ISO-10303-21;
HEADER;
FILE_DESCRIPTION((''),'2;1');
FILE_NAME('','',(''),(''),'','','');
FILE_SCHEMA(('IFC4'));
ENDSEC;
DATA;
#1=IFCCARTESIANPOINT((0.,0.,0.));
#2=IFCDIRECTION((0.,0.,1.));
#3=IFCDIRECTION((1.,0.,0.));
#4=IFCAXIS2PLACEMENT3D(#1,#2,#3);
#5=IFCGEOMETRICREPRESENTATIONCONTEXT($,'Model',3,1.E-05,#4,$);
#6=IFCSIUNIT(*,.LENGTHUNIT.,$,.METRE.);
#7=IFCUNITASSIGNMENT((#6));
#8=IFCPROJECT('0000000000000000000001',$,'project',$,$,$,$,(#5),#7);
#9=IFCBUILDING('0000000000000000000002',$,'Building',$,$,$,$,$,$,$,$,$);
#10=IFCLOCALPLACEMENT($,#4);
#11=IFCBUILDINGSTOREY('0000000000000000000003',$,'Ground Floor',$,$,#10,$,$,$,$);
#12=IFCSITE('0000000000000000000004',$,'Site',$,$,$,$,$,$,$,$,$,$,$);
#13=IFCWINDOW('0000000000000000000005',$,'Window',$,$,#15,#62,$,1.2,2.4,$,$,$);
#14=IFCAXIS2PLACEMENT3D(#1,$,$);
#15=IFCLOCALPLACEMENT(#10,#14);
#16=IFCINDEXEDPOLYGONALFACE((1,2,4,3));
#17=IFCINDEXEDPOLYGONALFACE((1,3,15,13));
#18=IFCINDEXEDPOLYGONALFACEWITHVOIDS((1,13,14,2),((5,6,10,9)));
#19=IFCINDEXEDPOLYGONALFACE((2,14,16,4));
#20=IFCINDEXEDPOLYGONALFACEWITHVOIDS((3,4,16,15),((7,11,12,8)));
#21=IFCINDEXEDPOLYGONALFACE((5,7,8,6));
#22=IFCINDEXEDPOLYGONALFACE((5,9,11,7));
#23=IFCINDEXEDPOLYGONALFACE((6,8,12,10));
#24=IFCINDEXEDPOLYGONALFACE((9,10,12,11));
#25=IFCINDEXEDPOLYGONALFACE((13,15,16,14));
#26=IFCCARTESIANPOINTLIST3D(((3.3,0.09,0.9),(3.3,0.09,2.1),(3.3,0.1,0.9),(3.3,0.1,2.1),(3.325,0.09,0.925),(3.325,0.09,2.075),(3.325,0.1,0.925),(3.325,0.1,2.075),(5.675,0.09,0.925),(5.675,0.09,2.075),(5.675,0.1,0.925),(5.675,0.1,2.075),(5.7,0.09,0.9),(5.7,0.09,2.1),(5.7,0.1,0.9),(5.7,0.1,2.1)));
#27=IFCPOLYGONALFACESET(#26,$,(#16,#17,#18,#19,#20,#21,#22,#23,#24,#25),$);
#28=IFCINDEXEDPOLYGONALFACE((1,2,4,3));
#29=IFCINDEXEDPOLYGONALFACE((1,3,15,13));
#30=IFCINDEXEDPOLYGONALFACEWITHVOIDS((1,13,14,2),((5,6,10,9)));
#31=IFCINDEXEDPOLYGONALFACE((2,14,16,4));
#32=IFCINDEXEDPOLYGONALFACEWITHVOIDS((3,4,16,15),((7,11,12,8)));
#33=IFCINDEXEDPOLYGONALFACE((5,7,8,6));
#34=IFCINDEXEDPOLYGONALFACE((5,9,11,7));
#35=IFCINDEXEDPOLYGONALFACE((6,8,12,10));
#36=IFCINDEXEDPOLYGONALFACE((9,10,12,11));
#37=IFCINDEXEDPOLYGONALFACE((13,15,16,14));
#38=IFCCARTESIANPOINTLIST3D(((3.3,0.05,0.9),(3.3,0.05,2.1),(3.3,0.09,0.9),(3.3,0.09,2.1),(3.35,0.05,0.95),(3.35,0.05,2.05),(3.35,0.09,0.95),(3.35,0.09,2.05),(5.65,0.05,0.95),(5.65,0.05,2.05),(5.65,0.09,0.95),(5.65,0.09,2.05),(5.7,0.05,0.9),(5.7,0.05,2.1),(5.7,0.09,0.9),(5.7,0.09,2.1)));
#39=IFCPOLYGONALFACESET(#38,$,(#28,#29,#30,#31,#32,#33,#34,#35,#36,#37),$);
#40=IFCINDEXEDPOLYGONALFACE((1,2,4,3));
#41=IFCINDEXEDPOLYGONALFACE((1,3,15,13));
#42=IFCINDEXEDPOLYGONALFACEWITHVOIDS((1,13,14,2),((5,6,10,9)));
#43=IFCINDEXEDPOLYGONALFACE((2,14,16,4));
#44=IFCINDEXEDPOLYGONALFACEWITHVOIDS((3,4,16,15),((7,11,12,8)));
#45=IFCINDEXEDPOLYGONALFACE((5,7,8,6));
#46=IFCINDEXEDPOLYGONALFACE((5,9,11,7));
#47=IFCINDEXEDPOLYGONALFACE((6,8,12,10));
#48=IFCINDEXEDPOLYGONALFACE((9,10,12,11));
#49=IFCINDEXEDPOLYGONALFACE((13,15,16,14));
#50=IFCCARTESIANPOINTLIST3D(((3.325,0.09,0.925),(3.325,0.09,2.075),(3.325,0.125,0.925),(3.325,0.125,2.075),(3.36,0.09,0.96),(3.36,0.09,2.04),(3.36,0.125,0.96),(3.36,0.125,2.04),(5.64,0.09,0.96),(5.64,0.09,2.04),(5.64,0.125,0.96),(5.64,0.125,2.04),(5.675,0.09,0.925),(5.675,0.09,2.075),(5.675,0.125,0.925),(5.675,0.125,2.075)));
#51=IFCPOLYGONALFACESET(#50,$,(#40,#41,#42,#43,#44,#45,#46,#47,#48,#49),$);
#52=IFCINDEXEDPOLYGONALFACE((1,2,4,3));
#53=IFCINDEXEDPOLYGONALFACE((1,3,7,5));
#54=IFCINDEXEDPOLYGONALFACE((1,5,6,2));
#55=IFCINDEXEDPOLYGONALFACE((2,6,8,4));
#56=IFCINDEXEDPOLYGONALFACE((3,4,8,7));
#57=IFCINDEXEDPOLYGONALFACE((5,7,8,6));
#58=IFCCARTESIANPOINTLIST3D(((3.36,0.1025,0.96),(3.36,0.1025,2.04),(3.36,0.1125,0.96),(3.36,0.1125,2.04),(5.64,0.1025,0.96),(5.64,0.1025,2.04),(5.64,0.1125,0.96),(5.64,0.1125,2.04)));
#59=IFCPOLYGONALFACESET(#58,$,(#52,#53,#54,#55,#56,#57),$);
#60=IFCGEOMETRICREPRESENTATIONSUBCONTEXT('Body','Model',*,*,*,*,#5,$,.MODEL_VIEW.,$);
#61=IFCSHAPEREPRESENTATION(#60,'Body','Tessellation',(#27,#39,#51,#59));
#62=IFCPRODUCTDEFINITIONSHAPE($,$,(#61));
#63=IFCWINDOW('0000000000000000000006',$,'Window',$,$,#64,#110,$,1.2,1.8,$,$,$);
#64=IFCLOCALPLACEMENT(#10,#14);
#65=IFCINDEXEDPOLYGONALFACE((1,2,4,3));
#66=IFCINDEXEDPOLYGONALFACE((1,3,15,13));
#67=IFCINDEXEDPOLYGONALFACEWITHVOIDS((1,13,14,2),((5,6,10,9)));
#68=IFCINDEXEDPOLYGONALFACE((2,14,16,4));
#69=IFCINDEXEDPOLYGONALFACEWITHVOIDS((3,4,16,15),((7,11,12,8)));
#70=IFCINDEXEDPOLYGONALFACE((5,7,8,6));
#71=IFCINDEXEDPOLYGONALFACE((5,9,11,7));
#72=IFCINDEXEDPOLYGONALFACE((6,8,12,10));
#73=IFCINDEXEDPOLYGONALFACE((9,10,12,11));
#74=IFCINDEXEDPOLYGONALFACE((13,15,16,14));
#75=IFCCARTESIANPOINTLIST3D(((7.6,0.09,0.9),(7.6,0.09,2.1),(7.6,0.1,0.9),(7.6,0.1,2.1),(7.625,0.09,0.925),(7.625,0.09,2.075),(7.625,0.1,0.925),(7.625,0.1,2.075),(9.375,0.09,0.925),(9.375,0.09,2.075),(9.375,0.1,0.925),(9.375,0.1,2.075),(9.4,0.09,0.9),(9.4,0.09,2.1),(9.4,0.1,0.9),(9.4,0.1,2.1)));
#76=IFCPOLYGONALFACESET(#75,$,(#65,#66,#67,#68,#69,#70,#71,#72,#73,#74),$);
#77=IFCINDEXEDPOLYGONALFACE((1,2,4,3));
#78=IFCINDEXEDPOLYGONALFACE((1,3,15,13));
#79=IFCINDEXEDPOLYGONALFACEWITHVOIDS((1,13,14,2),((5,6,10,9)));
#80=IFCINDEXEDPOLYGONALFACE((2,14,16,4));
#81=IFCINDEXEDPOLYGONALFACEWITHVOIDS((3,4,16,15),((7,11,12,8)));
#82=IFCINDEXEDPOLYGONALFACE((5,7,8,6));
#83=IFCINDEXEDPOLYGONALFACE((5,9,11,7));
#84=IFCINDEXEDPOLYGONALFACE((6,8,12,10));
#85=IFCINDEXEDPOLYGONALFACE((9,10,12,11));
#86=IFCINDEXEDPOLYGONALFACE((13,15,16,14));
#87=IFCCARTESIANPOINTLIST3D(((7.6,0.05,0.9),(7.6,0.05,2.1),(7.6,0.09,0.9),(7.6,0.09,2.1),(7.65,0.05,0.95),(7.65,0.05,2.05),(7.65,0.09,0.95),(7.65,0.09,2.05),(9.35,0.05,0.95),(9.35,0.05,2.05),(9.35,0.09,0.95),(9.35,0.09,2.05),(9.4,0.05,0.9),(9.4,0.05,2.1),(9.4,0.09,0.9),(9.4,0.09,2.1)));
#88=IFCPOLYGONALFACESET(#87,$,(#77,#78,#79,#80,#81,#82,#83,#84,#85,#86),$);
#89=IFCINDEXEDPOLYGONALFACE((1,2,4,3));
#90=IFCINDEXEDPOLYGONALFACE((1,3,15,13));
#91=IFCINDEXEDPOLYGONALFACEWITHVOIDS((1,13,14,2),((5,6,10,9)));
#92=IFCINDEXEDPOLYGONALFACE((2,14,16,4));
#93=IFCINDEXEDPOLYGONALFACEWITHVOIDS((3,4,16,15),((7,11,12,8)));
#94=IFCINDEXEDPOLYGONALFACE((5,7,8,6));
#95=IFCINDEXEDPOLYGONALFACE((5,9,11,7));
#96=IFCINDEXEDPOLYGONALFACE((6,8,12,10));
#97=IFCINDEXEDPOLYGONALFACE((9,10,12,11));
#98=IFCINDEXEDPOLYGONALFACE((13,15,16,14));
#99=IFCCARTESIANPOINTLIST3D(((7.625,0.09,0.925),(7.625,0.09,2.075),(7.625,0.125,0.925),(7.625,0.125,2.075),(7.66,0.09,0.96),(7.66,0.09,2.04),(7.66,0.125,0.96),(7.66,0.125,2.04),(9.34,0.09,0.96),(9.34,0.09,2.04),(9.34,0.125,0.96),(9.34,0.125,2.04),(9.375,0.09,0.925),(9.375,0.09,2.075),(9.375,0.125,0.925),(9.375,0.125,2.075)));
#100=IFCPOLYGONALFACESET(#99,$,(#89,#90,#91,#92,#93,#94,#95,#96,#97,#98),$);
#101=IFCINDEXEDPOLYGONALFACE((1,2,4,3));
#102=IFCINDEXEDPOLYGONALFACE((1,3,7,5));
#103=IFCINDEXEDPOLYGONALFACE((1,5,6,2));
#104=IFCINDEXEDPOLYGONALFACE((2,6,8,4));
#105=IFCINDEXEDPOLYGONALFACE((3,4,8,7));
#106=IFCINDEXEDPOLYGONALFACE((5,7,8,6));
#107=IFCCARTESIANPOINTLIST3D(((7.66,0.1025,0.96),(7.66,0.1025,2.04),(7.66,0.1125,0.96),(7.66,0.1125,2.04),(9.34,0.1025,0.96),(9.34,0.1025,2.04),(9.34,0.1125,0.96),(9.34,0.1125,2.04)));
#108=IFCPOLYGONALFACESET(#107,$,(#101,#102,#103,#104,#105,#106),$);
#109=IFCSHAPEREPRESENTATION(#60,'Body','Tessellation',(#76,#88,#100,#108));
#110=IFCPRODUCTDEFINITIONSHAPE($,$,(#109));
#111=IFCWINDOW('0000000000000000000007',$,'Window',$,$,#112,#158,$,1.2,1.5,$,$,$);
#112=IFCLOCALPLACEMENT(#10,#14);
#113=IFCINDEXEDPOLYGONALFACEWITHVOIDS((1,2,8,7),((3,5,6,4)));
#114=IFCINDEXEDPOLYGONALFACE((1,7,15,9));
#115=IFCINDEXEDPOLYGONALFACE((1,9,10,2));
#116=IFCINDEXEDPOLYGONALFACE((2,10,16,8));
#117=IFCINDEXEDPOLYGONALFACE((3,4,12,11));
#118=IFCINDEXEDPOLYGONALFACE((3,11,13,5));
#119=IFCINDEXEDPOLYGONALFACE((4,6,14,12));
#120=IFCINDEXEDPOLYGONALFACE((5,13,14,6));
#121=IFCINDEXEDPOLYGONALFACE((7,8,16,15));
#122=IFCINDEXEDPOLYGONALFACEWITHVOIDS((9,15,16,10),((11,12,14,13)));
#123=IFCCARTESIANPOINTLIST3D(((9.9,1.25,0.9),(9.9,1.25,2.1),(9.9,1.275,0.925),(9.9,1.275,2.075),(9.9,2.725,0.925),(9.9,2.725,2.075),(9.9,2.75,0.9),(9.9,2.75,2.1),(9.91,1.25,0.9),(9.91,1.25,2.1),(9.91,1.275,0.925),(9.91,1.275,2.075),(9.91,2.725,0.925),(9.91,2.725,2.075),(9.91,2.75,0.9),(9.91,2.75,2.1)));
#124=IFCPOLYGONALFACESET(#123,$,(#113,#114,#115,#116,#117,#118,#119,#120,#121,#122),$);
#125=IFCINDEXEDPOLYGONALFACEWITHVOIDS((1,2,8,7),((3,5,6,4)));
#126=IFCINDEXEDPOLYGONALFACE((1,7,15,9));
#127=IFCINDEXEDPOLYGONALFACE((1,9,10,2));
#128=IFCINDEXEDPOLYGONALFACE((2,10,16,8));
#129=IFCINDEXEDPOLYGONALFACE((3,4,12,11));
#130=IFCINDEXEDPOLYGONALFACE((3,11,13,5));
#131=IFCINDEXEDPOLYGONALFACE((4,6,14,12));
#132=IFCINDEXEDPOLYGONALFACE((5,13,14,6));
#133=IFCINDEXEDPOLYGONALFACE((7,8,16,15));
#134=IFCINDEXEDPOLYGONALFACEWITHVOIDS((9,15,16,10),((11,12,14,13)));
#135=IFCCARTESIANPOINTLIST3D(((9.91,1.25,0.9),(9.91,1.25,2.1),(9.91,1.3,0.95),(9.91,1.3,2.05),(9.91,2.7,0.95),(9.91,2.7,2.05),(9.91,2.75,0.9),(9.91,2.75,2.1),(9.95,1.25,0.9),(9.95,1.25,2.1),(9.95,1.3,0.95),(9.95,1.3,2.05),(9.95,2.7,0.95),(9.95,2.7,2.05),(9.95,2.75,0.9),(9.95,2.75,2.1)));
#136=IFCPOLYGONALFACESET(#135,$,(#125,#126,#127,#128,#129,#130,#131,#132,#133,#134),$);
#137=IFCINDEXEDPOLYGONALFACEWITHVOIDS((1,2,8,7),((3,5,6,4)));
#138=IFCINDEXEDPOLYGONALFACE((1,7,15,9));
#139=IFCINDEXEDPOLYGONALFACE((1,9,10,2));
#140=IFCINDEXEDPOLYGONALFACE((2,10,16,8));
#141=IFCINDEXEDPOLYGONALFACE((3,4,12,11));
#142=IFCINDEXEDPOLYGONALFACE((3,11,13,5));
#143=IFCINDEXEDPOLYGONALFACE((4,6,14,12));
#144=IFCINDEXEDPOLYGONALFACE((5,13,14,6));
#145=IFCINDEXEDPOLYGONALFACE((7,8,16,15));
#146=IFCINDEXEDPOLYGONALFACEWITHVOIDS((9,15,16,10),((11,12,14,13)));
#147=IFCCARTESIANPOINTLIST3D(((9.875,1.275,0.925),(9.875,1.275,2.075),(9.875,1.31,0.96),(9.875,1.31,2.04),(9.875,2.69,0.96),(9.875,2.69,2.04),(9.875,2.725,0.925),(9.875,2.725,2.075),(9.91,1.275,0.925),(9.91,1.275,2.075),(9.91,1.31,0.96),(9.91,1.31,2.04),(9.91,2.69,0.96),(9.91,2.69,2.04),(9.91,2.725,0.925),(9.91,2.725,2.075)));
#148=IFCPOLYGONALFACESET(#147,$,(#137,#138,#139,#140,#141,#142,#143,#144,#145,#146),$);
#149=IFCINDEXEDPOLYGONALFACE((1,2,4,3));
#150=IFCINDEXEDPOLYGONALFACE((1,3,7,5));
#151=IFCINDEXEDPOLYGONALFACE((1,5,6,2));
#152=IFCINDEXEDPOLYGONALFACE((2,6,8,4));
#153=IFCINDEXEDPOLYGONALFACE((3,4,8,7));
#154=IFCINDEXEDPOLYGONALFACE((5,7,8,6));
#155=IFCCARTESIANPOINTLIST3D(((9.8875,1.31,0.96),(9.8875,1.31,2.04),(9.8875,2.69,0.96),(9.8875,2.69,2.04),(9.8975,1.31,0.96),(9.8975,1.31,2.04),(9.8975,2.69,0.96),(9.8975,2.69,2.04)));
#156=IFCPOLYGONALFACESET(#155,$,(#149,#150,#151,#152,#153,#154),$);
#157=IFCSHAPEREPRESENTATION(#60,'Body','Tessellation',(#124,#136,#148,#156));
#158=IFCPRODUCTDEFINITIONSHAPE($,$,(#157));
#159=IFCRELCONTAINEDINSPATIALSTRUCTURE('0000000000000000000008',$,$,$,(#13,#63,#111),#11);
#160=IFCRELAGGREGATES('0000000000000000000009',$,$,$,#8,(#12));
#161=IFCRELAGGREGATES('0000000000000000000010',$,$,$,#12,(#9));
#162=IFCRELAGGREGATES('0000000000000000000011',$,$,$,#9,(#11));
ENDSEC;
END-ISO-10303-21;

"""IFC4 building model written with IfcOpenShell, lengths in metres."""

from ifc_helpers import new_model, si_unit, frame, origin_with_axes, place, context, subcontext, project, spatial, line, indexed_curve, outline, extrude, element, save


model = new_model("IFC4")

# Units and contexts
model_context = context("Model", 3, precision=1e-05, world=origin_with_axes())
body_context = subcontext(model_context, "Body", "Model", "MODEL_VIEW")
ifc_project = project(units=[si_unit("LENGTHUNIT", "METRE")], contexts=[model_context])

# Site, building, storey
site = spatial("IfcSite", under=ifc_project, Name="Site")
building = spatial("IfcBuilding", under=site, Name="Building")
storey_placement = place(None, origin_with_axes())
storey = spatial("IfcBuildingStorey", under=building, at=storey_placement, Name="Ground Floor")

# Windows
window_1_placement = place(storey_placement, frame((3.3, 0.0, 0.9), z_axis=(0.0, 0.0, 1.0), x_axis=(1.0, 0.0, 0.0)))
element("IfcWindow", 1, at=window_1_placement, inside=storey, Name="Window", OverallHeight=1.2, OverallWidth=2.4, context=body_context, shape_type="SweptSolid", body=[
    extrude(outline(indexed_curve([(0.0, 0.0), (2.4, 0.0), (2.4, 1.2), (0.0, 1.2)], segments=[line(1, 2, 3, 4, 1)]), holes=[indexed_curve([(0.025, 0.025), (2.375, 0.025), (2.375, 1.175), (0.025, 1.175)], segments=[line(1, 2, 3, 4, 1)])]), frame((0.0, 0.09, 0.0), z_axis=(0.0, -1.0, 0.0), x_axis=(1.0, 0.0, 0.0)), (0.0, 0.0, -1.0), 0.01),
    extrude(outline(indexed_curve([(0.0, 0.0), (2.4, 0.0), (2.4, 1.2), (0.0, 1.2)], segments=[line(1, 2, 3, 4, 1)]), holes=[indexed_curve([(0.05, 0.05), (2.35, 0.05), (2.35, 1.15), (0.05, 1.15)], segments=[line(1, 2, 3, 4, 1)])]), frame((0.0, 0.05, 0.0), z_axis=(0.0, -1.0, 0.0), x_axis=(1.0, 0.0, 0.0)), (0.0, 0.0, -1.0), 0.04),
    extrude(outline(indexed_curve([(0.0, 0.0), (2.35, 0.0), (2.35, 1.15), (0.0, 1.15)], segments=[line(1, 2, 3, 4, 1)]), holes=[indexed_curve([(0.035, 0.035), (2.315, 0.035), (2.315, 1.115), (0.035, 1.115)], segments=[line(1, 2, 3, 4, 1)])]), frame((0.025, 0.09, 0.025), z_axis=(0.0, -1.0, 0.0), x_axis=(1.0, 0.0, 0.0)), (0.0, 0.0, -1.0), 0.035),
    extrude(outline(indexed_curve([(0.035, 0.035), (2.315, 0.035), (2.315, 1.115), (0.035, 1.115)], segments=[line(1, 2, 3, 4, 1)])), frame((0.025, 0.1025, 0.025), z_axis=(0.0, -1.0, 0.0), x_axis=(1.0, 0.0, 0.0)), (0.0, 0.0, -1.0), 0.01),
])
window_2_placement = place(storey_placement, frame((7.6, 0.0, 0.9), z_axis=(0.0, 0.0, 1.0), x_axis=(1.0, 0.0, 0.0)))
element("IfcWindow", 2, at=window_2_placement, inside=storey, Name="Window", OverallHeight=1.2, OverallWidth=1.8, context=body_context, shape_type="SweptSolid", body=[
    extrude(outline(indexed_curve([(0.0, 0.0), (1.8, 0.0), (1.8, 1.2), (0.0, 1.2)], segments=[line(1, 2, 3, 4, 1)]), holes=[indexed_curve([(0.025, 0.025), (1.775, 0.025), (1.775, 1.175), (0.025, 1.175)], segments=[line(1, 2, 3, 4, 1)])]), frame((0.0, 0.09, 0.0), z_axis=(0.0, -1.0, 0.0), x_axis=(1.0, 0.0, 0.0)), (0.0, 0.0, -1.0), 0.01),
    extrude(outline(indexed_curve([(0.0, 0.0), (1.8, 0.0), (1.8, 1.2), (0.0, 1.2)], segments=[line(1, 2, 3, 4, 1)]), holes=[indexed_curve([(0.05, 0.05), (1.75, 0.05), (1.75, 1.15), (0.05, 1.15)], segments=[line(1, 2, 3, 4, 1)])]), frame((0.0, 0.05, 0.0), z_axis=(0.0, -1.0, 0.0), x_axis=(1.0, 0.0, 0.0)), (0.0, 0.0, -1.0), 0.04),
    extrude(outline(indexed_curve([(0.0, 0.0), (1.75, 0.0), (1.75, 1.15), (0.0, 1.15)], segments=[line(1, 2, 3, 4, 1)]), holes=[indexed_curve([(0.035, 0.035), (1.715, 0.035), (1.715, 1.115), (0.035, 1.115)], segments=[line(1, 2, 3, 4, 1)])]), frame((0.025, 0.09, 0.025), z_axis=(0.0, -1.0, 0.0), x_axis=(1.0, 0.0, 0.0)), (0.0, 0.0, -1.0), 0.035),
    extrude(outline(indexed_curve([(0.035, 0.035), (1.715, 0.035), (1.715, 1.115), (0.035, 1.115)], segments=[line(1, 2, 3, 4, 1)])), frame((0.025, 0.1025, 0.025), z_axis=(0.0, -1.0, 0.0), x_axis=(1.0, 0.0, 0.0)), (0.0, 0.0, -1.0), 0.01),
])
window_3_placement = place(storey_placement, frame((10.0, 1.25, 0.9), z_axis=(0.0, 0.0, 1.0), x_axis=(0.0, 1.0, 0.0)))
element("IfcWindow", 3, at=window_3_placement, inside=storey, Name="Window", OverallHeight=1.2, OverallWidth=1.5, context=body_context, shape_type="SweptSolid", body=[
    extrude(outline(indexed_curve([(0.0, 0.0), (1.5, 0.0), (1.5, 1.2), (0.0, 1.2)], segments=[line(1, 2, 3, 4, 1)]), holes=[indexed_curve([(0.025, 0.025), (1.475, 0.025), (1.475, 1.175), (0.025, 1.175)], segments=[line(1, 2, 3, 4, 1)])]), frame((0.0, 0.09, 0.0), z_axis=(0.0, -1.0, 0.0), x_axis=(1.0, 0.0, 0.0)), (0.0, 0.0, -1.0), 0.01),
    extrude(outline(indexed_curve([(0.0, 0.0), (1.5, 0.0), (1.5, 1.2), (0.0, 1.2)], segments=[line(1, 2, 3, 4, 1)]), holes=[indexed_curve([(0.05, 0.05), (1.45, 0.05), (1.45, 1.15), (0.05, 1.15)], segments=[line(1, 2, 3, 4, 1)])]), frame((0.0, 0.05, 0.0), z_axis=(0.0, -1.0, 0.0), x_axis=(1.0, 0.0, 0.0)), (0.0, 0.0, -1.0), 0.04),
    extrude(outline(indexed_curve([(0.0, 0.0), (1.45, 0.0), (1.45, 1.15), (0.0, 1.15)], segments=[line(1, 2, 3, 4, 1)]), holes=[indexed_curve([(0.035, 0.035), (1.415, 0.035), (1.415, 1.115), (0.035, 1.115)], segments=[line(1, 2, 3, 4, 1)])]), frame((0.025, 0.09, 0.025), z_axis=(0.0, -1.0, 0.0), x_axis=(1.0, 0.0, 0.0)), (0.0, 0.0, -1.0), 0.035),
    extrude(outline(indexed_curve([(0.035, 0.035), (1.415, 0.035), (1.415, 1.115), (0.035, 1.115)], segments=[line(1, 2, 3, 4, 1)])), frame((0.025, 0.1025, 0.025), z_axis=(0.0, -1.0, 0.0), x_axis=(1.0, 0.0, 0.0)), (0.0, 0.0, -1.0), 0.01),
])

save(model, "model.ifc")
